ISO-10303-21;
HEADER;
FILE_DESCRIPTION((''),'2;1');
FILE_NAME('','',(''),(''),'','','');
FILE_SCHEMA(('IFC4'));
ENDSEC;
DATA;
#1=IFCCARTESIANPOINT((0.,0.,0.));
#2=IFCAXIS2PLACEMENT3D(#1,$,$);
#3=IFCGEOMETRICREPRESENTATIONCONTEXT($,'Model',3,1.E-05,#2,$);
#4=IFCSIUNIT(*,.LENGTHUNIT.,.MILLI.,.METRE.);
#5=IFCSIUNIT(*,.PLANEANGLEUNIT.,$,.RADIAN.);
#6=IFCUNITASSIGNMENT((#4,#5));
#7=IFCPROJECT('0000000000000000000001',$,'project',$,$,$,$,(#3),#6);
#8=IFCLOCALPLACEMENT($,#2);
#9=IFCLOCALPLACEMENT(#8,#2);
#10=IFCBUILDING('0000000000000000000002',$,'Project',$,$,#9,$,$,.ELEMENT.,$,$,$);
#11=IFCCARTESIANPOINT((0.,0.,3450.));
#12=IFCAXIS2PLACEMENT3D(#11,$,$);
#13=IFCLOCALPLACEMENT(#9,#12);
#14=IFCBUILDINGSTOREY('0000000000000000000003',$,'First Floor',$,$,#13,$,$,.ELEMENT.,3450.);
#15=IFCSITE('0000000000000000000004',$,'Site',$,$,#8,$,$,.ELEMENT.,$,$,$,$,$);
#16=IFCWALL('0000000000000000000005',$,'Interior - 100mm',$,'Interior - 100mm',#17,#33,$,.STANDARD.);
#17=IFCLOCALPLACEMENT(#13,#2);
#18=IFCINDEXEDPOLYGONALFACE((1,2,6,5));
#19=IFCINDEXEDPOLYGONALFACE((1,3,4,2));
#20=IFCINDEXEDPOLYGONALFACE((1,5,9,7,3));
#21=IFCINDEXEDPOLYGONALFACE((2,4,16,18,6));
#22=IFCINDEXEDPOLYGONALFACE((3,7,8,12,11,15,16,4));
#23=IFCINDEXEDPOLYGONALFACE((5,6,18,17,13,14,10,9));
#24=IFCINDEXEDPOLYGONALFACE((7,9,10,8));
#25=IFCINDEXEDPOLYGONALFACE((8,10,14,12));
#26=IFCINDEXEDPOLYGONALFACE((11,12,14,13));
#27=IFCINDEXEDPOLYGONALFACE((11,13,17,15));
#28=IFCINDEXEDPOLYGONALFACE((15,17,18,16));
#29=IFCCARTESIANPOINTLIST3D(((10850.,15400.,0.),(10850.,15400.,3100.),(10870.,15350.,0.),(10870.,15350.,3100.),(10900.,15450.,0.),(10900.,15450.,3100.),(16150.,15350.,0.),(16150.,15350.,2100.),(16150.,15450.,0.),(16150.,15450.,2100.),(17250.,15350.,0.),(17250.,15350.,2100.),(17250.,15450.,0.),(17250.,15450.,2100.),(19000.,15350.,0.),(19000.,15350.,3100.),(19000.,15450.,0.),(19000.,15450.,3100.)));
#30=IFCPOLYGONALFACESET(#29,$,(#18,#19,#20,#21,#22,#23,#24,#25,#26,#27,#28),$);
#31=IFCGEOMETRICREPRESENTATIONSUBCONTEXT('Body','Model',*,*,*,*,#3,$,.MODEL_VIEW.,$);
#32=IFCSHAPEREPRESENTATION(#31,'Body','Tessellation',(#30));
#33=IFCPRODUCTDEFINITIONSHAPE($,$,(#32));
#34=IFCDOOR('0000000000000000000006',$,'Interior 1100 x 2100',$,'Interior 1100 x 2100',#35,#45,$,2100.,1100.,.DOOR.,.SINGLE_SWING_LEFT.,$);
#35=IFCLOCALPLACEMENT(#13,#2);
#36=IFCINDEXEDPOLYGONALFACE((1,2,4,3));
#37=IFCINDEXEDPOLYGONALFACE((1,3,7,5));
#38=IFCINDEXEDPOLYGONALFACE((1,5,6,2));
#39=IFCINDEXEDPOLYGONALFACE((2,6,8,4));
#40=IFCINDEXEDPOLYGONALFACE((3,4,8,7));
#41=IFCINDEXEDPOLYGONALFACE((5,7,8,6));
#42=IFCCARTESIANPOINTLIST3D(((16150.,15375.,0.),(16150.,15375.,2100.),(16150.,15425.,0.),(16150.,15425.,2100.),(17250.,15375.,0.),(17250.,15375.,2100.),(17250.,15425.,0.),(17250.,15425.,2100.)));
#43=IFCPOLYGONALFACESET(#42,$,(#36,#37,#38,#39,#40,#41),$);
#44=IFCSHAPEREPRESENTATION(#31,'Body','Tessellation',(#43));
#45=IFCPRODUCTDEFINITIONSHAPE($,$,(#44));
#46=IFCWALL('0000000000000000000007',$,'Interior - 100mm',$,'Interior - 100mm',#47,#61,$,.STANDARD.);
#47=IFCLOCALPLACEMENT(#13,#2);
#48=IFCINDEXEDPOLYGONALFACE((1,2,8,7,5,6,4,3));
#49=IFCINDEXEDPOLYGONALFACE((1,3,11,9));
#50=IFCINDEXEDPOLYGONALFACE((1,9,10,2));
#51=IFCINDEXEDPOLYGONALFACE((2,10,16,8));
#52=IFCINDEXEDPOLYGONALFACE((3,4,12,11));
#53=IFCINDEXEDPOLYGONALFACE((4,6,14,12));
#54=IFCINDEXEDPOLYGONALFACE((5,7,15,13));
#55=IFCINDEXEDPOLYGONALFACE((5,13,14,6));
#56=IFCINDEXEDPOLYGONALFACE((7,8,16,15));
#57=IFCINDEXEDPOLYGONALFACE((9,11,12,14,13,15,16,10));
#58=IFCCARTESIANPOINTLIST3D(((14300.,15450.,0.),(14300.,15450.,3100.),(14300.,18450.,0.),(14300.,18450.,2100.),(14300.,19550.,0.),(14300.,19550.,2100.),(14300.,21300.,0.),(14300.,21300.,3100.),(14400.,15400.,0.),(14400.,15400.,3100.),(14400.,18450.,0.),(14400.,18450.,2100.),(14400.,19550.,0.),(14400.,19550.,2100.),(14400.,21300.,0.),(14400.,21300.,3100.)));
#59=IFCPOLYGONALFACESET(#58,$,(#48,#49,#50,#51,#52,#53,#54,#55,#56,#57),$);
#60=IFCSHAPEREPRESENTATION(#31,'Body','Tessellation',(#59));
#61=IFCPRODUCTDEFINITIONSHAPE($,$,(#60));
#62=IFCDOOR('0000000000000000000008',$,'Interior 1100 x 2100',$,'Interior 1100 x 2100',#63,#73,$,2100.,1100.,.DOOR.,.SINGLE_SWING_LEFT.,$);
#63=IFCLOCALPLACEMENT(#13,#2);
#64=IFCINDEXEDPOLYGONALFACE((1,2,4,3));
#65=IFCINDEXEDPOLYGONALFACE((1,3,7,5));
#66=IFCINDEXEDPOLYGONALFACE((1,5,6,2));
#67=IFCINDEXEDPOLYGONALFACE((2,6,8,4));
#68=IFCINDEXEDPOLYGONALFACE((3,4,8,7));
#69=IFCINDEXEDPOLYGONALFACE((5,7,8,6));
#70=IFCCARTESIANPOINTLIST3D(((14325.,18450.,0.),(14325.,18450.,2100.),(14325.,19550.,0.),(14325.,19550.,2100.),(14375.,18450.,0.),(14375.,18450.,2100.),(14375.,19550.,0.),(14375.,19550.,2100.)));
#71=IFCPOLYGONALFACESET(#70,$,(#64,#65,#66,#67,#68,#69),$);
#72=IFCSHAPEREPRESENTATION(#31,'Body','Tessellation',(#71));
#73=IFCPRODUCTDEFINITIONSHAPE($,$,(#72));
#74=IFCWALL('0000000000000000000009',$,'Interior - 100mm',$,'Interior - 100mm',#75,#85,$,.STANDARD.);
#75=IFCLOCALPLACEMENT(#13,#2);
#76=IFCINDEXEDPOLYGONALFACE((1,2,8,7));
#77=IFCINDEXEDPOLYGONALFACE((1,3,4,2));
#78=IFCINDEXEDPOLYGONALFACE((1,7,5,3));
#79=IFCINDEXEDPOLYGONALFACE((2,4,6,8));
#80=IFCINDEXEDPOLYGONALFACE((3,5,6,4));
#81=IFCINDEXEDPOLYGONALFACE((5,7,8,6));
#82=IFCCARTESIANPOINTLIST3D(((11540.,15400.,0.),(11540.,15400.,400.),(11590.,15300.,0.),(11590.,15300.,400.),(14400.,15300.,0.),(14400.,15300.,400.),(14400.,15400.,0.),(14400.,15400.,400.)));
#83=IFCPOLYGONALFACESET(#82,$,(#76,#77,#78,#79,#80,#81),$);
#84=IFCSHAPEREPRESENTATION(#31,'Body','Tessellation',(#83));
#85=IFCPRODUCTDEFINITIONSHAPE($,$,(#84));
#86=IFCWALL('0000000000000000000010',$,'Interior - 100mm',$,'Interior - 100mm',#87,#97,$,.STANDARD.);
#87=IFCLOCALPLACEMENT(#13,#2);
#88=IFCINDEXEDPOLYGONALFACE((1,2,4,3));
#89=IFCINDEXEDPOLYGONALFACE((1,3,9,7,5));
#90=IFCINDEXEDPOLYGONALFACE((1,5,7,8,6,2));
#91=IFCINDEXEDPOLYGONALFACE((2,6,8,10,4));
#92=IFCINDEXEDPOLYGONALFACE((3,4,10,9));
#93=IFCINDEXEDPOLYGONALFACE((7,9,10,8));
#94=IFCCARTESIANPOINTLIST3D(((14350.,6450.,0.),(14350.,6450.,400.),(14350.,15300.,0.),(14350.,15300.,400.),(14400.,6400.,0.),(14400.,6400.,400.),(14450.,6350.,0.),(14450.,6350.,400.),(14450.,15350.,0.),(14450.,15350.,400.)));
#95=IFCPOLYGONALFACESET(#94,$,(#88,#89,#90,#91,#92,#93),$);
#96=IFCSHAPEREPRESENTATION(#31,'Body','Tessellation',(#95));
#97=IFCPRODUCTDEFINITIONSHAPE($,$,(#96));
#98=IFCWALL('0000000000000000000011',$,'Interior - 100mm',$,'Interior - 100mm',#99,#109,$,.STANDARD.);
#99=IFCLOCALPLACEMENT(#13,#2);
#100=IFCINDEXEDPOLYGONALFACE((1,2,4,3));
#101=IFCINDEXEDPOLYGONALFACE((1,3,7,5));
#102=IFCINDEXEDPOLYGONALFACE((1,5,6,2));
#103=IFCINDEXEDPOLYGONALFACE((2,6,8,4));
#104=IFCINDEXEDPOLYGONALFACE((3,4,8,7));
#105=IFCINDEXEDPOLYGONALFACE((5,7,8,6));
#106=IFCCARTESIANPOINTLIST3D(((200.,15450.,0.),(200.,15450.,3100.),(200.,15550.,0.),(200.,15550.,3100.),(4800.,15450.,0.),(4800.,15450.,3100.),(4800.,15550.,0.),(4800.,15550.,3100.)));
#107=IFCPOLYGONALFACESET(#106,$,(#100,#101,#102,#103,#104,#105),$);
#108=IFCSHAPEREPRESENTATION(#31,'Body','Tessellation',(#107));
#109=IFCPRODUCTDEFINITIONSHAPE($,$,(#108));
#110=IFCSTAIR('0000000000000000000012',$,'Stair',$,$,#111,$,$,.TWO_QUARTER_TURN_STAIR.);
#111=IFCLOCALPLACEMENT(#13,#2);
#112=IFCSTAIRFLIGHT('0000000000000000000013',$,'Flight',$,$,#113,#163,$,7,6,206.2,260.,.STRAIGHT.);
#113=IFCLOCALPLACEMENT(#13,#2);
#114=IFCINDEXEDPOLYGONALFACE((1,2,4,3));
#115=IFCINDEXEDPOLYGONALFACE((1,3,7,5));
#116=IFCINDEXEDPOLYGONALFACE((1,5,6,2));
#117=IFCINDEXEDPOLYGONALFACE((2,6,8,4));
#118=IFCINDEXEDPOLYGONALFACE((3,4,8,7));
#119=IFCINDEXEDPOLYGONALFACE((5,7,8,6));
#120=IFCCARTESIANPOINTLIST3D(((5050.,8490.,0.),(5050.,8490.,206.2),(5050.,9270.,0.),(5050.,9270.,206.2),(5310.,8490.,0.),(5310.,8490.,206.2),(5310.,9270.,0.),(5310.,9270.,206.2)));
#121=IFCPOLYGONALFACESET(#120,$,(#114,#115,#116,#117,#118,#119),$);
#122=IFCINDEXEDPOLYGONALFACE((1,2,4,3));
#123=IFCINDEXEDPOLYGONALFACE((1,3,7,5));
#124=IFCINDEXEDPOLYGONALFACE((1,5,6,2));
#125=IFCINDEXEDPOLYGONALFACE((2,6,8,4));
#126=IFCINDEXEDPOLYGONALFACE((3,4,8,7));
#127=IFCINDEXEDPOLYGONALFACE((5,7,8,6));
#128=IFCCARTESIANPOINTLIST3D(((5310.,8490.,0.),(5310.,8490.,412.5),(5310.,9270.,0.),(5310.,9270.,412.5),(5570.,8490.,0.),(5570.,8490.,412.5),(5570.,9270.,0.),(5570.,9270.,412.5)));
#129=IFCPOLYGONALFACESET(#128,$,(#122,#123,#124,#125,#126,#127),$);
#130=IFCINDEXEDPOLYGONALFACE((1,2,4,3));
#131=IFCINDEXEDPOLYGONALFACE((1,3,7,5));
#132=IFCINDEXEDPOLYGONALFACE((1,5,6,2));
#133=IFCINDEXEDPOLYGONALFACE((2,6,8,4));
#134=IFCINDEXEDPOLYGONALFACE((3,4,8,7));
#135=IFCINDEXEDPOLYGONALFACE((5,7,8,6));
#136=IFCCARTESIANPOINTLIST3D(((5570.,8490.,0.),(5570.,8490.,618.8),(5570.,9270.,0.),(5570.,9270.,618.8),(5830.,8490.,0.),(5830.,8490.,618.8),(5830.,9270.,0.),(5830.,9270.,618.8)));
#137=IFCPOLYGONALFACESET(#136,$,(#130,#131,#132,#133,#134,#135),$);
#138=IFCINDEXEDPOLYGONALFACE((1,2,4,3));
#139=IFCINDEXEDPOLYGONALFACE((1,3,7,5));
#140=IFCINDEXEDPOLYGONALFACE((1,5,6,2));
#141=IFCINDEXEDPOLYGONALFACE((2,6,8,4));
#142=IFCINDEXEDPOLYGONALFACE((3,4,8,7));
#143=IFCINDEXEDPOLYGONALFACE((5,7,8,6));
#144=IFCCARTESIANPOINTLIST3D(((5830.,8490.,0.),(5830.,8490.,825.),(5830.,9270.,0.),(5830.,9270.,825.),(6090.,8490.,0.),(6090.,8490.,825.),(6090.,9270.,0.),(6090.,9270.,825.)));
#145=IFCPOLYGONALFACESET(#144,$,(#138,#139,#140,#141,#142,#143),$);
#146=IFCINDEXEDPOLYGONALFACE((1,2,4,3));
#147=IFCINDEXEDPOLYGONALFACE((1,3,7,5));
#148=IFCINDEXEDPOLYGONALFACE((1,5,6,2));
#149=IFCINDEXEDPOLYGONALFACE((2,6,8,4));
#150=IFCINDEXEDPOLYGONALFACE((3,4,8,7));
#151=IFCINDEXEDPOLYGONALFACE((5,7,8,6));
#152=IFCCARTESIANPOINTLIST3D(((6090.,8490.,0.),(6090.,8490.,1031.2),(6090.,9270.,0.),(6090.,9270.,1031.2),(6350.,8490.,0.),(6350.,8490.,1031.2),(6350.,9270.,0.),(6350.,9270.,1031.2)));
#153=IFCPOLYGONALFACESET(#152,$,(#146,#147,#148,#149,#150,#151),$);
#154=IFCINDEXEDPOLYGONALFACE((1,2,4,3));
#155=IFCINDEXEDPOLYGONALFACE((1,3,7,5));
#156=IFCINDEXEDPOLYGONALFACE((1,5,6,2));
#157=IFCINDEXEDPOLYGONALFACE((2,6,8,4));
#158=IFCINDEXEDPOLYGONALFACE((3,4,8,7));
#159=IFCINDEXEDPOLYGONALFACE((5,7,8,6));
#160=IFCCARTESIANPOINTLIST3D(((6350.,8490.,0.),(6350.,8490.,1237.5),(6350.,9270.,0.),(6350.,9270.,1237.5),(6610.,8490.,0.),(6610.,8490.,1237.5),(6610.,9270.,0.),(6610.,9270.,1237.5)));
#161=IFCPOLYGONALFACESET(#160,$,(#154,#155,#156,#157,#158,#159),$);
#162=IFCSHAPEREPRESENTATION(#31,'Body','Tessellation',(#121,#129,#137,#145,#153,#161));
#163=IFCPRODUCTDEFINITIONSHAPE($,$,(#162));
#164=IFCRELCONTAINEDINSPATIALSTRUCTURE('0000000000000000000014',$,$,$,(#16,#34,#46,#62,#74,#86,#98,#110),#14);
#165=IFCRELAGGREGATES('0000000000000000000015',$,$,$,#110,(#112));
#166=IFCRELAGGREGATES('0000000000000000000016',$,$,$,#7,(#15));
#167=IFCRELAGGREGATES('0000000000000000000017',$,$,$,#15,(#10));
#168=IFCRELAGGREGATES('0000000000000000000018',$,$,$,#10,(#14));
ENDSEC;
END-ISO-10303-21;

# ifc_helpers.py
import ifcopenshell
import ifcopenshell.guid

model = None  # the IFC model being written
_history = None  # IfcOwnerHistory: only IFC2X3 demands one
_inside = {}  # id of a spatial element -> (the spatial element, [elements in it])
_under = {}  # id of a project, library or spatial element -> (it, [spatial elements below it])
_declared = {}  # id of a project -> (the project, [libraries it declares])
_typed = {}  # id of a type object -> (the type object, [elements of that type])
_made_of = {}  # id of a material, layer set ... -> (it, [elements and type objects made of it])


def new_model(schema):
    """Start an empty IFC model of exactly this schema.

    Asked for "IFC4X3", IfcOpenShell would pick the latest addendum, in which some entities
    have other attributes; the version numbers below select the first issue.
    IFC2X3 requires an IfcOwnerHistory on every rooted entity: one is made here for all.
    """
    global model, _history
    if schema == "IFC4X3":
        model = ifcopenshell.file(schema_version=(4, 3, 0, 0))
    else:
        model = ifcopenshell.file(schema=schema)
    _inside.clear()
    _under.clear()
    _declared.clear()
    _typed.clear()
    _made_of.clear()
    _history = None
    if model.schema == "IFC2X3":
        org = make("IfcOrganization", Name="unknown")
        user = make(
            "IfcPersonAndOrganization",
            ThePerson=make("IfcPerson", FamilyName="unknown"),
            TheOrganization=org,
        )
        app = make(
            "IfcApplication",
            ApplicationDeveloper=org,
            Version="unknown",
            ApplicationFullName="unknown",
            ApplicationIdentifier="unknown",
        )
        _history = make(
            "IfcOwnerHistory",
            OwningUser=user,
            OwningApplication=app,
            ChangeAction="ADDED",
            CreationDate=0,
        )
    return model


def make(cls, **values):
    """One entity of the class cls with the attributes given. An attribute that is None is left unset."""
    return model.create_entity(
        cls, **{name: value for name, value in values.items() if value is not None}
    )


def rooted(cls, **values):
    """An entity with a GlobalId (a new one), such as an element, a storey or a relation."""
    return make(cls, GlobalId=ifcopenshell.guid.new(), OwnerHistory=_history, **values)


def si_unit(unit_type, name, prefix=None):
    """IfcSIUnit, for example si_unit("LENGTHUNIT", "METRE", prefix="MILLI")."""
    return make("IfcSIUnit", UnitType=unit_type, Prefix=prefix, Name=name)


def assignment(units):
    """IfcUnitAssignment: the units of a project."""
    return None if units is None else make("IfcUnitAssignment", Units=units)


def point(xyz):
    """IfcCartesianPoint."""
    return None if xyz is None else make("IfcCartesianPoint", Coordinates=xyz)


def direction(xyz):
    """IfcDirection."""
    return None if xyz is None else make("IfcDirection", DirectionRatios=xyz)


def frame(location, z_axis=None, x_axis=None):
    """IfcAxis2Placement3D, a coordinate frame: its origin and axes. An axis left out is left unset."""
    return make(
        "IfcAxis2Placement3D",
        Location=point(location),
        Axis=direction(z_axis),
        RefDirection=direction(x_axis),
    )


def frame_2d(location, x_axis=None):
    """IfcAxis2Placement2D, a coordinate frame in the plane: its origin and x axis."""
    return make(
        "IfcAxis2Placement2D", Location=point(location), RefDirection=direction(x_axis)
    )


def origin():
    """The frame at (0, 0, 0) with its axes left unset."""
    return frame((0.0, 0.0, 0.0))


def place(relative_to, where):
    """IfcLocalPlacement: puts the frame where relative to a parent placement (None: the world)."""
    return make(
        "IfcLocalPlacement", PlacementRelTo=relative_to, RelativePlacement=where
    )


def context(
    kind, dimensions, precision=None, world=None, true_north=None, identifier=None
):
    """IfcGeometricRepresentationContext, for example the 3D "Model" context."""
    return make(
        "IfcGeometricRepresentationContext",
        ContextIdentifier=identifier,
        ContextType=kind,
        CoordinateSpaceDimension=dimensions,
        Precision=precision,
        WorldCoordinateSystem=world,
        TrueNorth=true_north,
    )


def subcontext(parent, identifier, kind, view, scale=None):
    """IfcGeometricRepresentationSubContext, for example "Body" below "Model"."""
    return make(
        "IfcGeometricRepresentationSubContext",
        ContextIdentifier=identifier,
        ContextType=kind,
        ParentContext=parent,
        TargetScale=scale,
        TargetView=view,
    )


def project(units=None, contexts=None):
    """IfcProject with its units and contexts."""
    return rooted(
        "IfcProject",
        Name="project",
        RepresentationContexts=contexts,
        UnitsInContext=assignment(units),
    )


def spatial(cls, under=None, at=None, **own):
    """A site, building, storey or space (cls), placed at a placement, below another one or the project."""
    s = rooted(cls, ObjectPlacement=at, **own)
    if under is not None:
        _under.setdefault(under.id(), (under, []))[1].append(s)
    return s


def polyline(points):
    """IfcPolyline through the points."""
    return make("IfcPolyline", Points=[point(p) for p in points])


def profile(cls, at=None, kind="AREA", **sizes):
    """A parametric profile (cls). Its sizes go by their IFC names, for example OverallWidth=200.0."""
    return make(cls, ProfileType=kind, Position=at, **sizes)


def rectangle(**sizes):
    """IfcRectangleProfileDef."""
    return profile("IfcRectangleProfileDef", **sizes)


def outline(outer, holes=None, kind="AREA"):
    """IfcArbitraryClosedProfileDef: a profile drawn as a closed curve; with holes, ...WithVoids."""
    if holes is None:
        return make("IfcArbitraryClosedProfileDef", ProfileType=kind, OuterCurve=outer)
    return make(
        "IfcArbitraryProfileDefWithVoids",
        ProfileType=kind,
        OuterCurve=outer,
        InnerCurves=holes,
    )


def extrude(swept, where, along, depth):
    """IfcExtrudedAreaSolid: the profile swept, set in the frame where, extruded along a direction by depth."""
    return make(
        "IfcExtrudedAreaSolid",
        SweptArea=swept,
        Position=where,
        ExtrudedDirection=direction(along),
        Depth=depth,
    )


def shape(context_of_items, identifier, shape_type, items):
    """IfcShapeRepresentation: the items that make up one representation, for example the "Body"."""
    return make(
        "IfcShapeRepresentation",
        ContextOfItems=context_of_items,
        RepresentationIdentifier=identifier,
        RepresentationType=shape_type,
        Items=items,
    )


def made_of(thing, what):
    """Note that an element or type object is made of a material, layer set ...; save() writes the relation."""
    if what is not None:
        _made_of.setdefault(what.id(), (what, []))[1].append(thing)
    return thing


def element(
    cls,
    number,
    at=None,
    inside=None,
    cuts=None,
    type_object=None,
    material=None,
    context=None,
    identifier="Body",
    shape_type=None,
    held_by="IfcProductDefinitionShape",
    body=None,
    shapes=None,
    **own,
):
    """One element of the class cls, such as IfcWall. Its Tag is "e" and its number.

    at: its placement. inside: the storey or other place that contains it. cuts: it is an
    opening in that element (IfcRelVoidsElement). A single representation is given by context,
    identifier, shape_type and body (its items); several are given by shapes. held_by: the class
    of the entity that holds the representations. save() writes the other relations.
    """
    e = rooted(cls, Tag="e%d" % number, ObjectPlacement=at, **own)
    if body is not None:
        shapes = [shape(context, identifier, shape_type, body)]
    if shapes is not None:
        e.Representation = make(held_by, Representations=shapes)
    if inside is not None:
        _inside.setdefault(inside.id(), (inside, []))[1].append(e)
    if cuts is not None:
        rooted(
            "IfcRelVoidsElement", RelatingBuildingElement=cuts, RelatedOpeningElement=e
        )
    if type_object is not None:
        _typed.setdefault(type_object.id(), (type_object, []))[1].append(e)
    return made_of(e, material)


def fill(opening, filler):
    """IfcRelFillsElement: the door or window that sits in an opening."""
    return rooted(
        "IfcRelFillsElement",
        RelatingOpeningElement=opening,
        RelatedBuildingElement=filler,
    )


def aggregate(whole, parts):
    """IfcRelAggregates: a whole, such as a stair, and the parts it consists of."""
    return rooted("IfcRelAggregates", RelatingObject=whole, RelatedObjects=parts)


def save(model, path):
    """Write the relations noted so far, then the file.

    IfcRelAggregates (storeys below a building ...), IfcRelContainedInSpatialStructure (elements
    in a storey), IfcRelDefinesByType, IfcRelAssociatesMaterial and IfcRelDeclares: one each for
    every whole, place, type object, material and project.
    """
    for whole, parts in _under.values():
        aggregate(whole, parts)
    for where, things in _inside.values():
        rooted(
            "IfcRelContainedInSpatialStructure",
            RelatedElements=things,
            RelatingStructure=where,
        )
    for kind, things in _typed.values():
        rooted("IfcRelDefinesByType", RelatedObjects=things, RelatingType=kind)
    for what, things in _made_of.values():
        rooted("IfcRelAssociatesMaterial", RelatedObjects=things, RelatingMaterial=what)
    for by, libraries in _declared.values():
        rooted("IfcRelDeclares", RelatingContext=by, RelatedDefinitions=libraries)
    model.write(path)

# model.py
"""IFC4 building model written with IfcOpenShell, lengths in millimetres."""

from ifc_helpers import new_model, si_unit, frame, frame_2d, origin, place, context, subcontext, project, spatial, polyline, rectangle, outline, extrude, element, fill, aggregate, save


model = new_model("IFC4")

# Units and contexts
model_context = context("Model", 3, precision=1e-05, world=origin())
body_context = subcontext(model_context, "Body", "Model", "MODEL_VIEW")
ifc_project = project(units=[si_unit("LENGTHUNIT", "METRE", prefix="MILLI"), si_unit("PLANEANGLEUNIT", "RADIAN")], contexts=[model_context])

# Site, building, storey
site_placement = place(None, origin())
site = spatial("IfcSite", under=ifc_project, at=site_placement, Name="Site", CompositionType="ELEMENT")
building_placement = place(site_placement, origin())
building = spatial("IfcBuilding", under=site, at=building_placement, Name="Project", CompositionType="ELEMENT")
storey_placement = place(building_placement, frame((0.0, 0.0, 3450.0)))
storey = spatial("IfcBuildingStorey", under=building, at=storey_placement, Name="First Floor", CompositionType="ELEMENT", Elevation=3450.0)

# Walls, openings, doors
wall_1_placement = place(storey_placement, frame((10850.0, 15400.0, 0.0), z_axis=(0.0, 0.0, 1.0), x_axis=(1.0, 0.0, 0.0)))
wall_1 = element("IfcWall", 1, at=wall_1_placement, inside=storey, Name="Interior - 100mm", ObjectType="Interior - 100mm", PredefinedType="STANDARD", context=body_context, shape_type="SweptSolid", body=[
    extrude(outline(polyline([(20.0, -50.0), (0.0, 0.0), (50.0, 50.0), (8150.0, 50.0), (8150.0, -50.0), (20.0, -50.0)])), origin(), (0.0, 0.0, 1.0), 3100.0),
])
opening_1_placement = place(wall_1_placement, frame((5300.0, 0.0, 0.0), z_axis=(0.0, 0.0, 1.0), x_axis=(1.0, 0.0, 0.0)))
opening_1 = element("IfcOpeningElement", 2, at=opening_1_placement, cuts=wall_1, PredefinedType="OPENING", context=body_context, shape_type="SweptSolid", body=[
    extrude(rectangle(XDim=1100.0, YDim=120.0, at=frame_2d((550.0, 0.0))), origin(), (0.0, 0.0, 1.0), 2100.0),
])
door_1_placement = place(opening_1_placement, origin())
door_1 = element("IfcDoor", 3, at=door_1_placement, inside=storey, Name="Interior 1100 x 2100", ObjectType="Interior 1100 x 2100", OperationType="SINGLE_SWING_LEFT", OverallHeight=2100.0, OverallWidth=1100.0, PredefinedType="DOOR", context=body_context, shape_type="SweptSolid", body=[
    extrude(rectangle(XDim=1100.0, YDim=50.0, at=frame_2d((550.0, 0.0))), origin(), (0.0, 0.0, 1.0), 2100.0),
])
fill(opening_1, door_1)
wall_2_placement = place(storey_placement, frame((14350.0, 15400.0, 0.0), z_axis=(0.0, 0.0, 1.0), x_axis=(0.0, 1.0, 0.0)))
wall_2 = element("IfcWall", 4, at=wall_2_placement, inside=storey, Name="Interior - 100mm", ObjectType="Interior - 100mm", PredefinedType="STANDARD", context=body_context, shape_type="SweptSolid", body=[
    extrude(outline(polyline([(0.0, -50.0), (50.0, 50.0), (5900.0, 50.0), (5900.0, -50.0), (0.0, -50.0)])), origin(), (0.0, 0.0, 1.0), 3100.0),
])
opening_2_placement = place(wall_2_placement, frame((3050.0, 0.0, 0.0), z_axis=(0.0, 0.0, 1.0), x_axis=(1.0, 0.0, 0.0)))
opening_2 = element("IfcOpeningElement", 5, at=opening_2_placement, cuts=wall_2, PredefinedType="OPENING", context=body_context, shape_type="SweptSolid", body=[
    extrude(rectangle(XDim=1100.0, YDim=120.0, at=frame_2d((550.0, 0.0))), origin(), (0.0, 0.0, 1.0), 2100.0),
])
door_2_placement = place(opening_2_placement, origin())
door_2 = element("IfcDoor", 6, at=door_2_placement, inside=storey, Name="Interior 1100 x 2100", ObjectType="Interior 1100 x 2100", OperationType="SINGLE_SWING_LEFT", OverallHeight=2100.0, OverallWidth=1100.0, PredefinedType="DOOR", context=body_context, shape_type="SweptSolid", body=[
    extrude(rectangle(XDim=1100.0, YDim=50.0, at=frame_2d((550.0, 0.0))), origin(), (0.0, 0.0, 1.0), 2100.0),
])
fill(opening_2, door_2)

# Walls
wall_3_placement = place(storey_placement, frame((11540.0, 15350.0, 0.0), z_axis=(0.0, 0.0, 1.0), x_axis=(1.0, 0.0, 0.0)))
element("IfcWall", 7, at=wall_3_placement, inside=storey, Name="Interior - 100mm", ObjectType="Interior - 100mm", PredefinedType="STANDARD", context=body_context, shape_type="SweptSolid", body=[
    extrude(outline(polyline([(50.0, -50.0), (0.0, 50.0), (2860.0, 50.0), (2860.0, -50.0), (50.0, -50.0)])), origin(), (0.0, 0.0, 1.0), 400.0),
])
wall_4_placement = place(storey_placement, frame((14400.0, 15350.0, 0.0), z_axis=(0.0, 0.0, 1.0), x_axis=(0.0, -1.0, 0.0)))
element("IfcWall", 8, at=wall_4_placement, inside=storey, Name="Interior - 100mm", ObjectType="Interior - 100mm", PredefinedType="STANDARD", context=body_context, shape_type="SweptSolid", body=[
    extrude(outline(polyline([(50.0, -50.0), (0.0, 50.0), (9000.0, 50.0), (8950.0, 0.0), (8900.0, -50.0), (50.0, -50.0)])), origin(), (0.0, 0.0, 1.0), 400.0),
])
wall_5_placement = place(storey_placement, frame((200.0, 15500.0, 0.0), z_axis=(0.0, 0.0, 1.0), x_axis=(1.0, 0.0, 0.0)))
element("IfcWall", 9, at=wall_5_placement, inside=storey, Name="Interior - 100mm", ObjectType="Interior - 100mm", PredefinedType="STANDARD", context=body_context, shape_type="SweptSolid", body=[
    extrude(outline(polyline([(0.0, -50.0), (0.0, 50.0), (4600.0, 50.0), (4600.0, -50.0), (0.0, -50.0)])), origin(), (0.0, 0.0, 1.0), 3100.0),
])

# Stair, stair flight
stair_placement = place(storey_placement, origin())
stair = element("IfcStair", 10, at=stair_placement, inside=storey, Name="Stair", PredefinedType="TWO_QUARTER_TURN_STAIR")
stair_flight_1_placement = place(stair_placement, frame((5050.0, 8880.0, 0.0), z_axis=(0.0, 0.0, 1.0), x_axis=(1.0, 0.0, 0.0)))
stair_flight_1 = element("IfcStairFlight", 11, at=stair_flight_1_placement, Name="Flight", NumberOfRisers=7, NumberOfTreads=6, PredefinedType="STRAIGHT", RiserHeight=206.2, TreadLength=260.0, context=body_context, shape_type="SweptSolid", body=[
    extrude(rectangle(XDim=260.0, YDim=780.0, at=frame_2d((130.0, 0.0))), origin(), (0.0, 0.0, 1.0), 206.2),
    extrude(rectangle(XDim=260.0, YDim=780.0, at=frame_2d((390.0, 0.0))), origin(), (0.0, 0.0, 1.0), 412.5),
    extrude(rectangle(XDim=260.0, YDim=780.0, at=frame_2d((650.0, 0.0))), origin(), (0.0, 0.0, 1.0), 618.8),
    extrude(rectangle(XDim=260.0, YDim=780.0, at=frame_2d((910.0, 0.0))), origin(), (0.0, 0.0, 1.0), 825.0),
    extrude(rectangle(XDim=260.0, YDim=780.0, at=frame_2d((1170.0, 0.0))), origin(), (0.0, 0.0, 1.0), 1031.2),
    extrude(rectangle(XDim=260.0, YDim=780.0, at=frame_2d((1430.0, 0.0))), origin(), (0.0, 0.0, 1.0), 1237.5),
])
aggregate(stair, [stair_flight_1])

save(model, "model.ifc")
